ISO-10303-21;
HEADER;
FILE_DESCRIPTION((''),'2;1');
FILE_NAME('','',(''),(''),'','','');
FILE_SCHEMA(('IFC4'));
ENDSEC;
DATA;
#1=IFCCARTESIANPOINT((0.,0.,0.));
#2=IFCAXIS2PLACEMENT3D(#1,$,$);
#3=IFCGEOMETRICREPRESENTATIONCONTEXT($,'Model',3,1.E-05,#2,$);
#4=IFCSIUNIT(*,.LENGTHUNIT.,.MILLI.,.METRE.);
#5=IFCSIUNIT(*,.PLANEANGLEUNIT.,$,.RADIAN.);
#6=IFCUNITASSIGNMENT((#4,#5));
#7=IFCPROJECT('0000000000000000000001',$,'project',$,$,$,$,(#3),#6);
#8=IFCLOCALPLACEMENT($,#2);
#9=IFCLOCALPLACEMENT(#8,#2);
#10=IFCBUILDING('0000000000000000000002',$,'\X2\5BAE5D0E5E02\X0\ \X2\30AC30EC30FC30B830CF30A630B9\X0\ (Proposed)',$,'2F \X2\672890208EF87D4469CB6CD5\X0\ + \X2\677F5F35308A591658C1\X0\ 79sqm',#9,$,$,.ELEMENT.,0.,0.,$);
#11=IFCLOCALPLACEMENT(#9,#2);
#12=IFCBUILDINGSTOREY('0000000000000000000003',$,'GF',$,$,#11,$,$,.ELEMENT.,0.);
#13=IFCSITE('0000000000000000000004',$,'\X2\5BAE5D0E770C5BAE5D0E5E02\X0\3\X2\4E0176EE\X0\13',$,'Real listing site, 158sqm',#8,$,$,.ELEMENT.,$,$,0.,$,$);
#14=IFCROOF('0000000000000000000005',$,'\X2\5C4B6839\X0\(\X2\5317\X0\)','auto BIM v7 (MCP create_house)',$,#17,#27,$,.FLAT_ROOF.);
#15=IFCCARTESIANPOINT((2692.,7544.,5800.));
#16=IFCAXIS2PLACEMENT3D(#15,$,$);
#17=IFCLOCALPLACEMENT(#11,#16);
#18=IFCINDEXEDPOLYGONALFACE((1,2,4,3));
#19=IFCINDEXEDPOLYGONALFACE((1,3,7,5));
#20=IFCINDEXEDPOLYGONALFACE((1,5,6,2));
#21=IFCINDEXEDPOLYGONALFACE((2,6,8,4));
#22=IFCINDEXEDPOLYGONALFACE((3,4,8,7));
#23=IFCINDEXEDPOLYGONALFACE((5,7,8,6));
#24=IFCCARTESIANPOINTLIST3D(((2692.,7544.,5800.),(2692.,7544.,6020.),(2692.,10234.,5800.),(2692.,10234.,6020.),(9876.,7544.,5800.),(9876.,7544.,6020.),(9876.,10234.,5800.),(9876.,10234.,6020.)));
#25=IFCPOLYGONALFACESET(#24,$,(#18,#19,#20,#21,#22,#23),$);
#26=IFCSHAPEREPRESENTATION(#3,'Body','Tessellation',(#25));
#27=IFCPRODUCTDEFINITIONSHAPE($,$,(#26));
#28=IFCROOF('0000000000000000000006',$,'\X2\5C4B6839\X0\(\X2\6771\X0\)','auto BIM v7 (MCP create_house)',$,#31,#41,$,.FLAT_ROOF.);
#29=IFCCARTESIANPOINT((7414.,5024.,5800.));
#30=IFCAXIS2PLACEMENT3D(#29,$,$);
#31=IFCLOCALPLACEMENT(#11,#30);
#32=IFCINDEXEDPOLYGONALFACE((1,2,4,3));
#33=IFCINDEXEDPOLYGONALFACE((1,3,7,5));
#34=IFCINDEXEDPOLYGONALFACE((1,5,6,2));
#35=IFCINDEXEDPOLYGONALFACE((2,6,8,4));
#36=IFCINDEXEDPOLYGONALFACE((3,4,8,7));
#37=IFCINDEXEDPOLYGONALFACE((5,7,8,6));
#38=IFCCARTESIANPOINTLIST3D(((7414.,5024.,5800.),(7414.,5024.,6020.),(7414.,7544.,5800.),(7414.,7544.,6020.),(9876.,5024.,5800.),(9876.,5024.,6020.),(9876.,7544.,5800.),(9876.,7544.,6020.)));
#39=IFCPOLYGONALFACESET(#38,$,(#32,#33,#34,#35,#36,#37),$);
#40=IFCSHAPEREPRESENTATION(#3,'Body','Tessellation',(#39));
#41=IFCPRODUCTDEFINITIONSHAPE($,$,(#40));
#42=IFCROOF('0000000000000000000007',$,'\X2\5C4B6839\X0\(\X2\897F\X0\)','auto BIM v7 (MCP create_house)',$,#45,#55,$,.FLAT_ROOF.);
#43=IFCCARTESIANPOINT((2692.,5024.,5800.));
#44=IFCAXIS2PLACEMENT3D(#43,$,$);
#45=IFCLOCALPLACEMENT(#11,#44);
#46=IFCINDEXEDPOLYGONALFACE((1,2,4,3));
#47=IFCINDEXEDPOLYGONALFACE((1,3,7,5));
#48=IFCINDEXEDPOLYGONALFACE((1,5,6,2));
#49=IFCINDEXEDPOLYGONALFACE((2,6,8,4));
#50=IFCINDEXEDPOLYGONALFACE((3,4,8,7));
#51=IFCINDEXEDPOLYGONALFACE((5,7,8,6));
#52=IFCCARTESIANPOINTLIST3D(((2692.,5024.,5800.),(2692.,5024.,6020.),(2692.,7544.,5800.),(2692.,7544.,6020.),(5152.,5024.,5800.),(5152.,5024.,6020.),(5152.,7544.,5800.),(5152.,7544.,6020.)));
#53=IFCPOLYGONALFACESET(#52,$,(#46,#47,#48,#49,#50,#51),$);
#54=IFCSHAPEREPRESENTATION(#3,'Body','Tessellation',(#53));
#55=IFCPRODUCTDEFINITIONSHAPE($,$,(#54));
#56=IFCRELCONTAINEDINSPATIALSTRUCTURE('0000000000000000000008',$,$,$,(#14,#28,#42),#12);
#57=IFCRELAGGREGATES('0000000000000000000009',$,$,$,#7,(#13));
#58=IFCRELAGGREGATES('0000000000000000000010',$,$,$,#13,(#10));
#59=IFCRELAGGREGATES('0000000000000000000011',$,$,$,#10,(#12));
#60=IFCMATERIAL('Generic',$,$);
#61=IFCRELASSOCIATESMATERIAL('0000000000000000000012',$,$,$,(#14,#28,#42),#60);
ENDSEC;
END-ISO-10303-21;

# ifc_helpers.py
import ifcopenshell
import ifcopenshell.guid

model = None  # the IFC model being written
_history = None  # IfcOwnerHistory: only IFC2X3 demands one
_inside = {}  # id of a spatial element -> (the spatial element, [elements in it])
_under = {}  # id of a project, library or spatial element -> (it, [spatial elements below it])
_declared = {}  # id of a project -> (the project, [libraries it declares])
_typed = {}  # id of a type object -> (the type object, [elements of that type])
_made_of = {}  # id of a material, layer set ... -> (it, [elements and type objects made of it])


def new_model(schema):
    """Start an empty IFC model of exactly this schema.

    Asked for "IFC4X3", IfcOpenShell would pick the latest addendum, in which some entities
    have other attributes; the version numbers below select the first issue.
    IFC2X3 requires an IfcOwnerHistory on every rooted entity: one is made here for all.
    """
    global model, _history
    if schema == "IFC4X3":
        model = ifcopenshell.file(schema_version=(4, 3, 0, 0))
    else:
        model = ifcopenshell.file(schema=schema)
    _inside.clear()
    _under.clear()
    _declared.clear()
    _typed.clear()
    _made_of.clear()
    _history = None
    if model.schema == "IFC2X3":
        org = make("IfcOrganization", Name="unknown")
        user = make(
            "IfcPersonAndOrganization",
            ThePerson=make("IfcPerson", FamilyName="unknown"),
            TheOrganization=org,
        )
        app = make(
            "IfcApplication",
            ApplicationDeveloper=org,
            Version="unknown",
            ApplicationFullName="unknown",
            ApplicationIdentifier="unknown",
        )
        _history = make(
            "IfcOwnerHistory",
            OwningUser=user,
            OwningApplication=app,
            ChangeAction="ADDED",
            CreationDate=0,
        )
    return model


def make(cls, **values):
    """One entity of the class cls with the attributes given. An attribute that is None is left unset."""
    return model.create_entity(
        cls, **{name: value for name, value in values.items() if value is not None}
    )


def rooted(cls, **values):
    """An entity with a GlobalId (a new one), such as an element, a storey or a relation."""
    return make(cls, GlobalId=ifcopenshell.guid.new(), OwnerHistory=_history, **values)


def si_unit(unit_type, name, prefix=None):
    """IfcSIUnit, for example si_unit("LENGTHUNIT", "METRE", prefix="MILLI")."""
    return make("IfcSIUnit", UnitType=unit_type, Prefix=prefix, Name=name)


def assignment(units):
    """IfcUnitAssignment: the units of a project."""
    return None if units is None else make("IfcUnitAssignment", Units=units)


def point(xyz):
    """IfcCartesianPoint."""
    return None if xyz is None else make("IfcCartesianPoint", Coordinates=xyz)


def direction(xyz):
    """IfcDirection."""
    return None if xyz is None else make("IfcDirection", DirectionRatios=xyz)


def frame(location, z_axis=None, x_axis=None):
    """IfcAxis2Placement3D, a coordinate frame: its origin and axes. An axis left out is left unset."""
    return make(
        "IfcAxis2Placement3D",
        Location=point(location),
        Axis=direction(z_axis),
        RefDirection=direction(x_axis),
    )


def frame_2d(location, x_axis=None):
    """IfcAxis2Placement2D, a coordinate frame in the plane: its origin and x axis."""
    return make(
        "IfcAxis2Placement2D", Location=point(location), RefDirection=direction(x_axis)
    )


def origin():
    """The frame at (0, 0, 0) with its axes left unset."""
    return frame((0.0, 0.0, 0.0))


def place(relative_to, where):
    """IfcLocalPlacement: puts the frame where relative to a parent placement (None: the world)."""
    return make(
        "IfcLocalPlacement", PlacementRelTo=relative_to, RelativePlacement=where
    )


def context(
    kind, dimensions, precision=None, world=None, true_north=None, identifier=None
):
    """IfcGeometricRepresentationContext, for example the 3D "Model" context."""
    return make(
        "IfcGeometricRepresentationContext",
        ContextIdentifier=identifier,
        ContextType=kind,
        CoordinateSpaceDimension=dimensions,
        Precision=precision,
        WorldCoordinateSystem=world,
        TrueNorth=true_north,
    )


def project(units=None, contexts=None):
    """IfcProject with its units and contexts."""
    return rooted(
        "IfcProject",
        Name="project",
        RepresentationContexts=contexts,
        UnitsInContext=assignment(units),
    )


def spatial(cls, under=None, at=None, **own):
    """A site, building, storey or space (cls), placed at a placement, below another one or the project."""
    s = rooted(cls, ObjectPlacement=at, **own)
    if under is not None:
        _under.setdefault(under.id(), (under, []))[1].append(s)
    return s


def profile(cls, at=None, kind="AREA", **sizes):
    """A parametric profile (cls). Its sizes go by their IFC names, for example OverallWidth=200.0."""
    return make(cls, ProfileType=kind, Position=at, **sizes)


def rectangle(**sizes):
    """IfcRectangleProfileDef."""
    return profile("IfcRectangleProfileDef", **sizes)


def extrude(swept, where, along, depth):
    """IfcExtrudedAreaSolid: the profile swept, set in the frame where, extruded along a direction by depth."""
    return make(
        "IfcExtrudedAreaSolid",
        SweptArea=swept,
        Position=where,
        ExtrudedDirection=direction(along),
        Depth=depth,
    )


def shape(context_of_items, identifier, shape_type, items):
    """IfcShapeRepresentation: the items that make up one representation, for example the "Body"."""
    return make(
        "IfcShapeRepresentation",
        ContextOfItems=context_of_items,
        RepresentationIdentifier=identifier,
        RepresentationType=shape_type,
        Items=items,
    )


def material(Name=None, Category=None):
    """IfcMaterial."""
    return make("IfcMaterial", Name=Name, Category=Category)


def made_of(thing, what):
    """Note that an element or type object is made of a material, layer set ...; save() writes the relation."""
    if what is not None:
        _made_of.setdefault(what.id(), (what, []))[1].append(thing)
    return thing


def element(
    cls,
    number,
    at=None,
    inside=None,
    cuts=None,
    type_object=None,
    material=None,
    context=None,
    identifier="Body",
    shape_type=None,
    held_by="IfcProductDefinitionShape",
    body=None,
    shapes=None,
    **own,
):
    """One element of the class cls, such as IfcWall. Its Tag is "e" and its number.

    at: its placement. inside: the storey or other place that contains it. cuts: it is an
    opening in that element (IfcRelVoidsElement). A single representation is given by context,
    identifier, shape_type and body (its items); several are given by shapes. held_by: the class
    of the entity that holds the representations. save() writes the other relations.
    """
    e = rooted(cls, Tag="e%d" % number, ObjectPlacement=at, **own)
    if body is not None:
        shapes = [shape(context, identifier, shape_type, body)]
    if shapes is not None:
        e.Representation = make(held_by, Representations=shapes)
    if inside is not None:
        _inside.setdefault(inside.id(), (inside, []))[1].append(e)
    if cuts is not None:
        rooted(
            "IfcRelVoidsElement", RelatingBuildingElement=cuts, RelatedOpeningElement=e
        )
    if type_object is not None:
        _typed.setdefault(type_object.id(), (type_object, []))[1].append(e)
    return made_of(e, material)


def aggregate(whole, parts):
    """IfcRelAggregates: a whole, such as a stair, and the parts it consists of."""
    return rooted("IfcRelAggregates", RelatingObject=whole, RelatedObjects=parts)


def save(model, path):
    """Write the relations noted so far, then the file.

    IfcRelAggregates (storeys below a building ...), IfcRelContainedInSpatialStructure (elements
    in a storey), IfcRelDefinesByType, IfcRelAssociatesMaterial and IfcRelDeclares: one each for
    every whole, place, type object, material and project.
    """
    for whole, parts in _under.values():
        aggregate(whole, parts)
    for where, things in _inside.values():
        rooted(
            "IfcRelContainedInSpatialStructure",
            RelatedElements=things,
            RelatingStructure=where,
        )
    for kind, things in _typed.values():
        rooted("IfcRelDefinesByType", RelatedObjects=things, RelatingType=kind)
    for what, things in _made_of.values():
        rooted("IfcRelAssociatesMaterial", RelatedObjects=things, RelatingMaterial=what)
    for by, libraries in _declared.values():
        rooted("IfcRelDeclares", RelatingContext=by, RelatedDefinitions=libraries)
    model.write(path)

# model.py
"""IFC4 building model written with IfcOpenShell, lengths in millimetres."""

from ifc_helpers import new_model, si_unit, frame, frame_2d, origin, place, context, project, spatial, rectangle, extrude, material, element, save


model = new_model("IFC4")

# Units and contexts
model_context = context("Model", 3, precision=1e-05, world=origin())
ifc_project = project(units=[si_unit("LENGTHUNIT", "METRE", prefix="MILLI"), si_unit("PLANEANGLEUNIT", "RADIAN")], contexts=[model_context])

# Site, building, storey
site_placement = place(None, origin())
site = spatial("IfcSite", under=ifc_project, at=site_placement, Name="宮崎県宮崎市3丁目13", ObjectType="Real listing site, 158sqm", CompositionType="ELEMENT", RefElevation=0.0)
building_placement = place(site_placement, origin())
building = spatial("IfcBuilding", under=site, at=building_placement, Name="宮崎市 ガレージハウス (Proposed)", ObjectType="2F 木造軸組構法 + 板張り外壁 79sqm", CompositionType="ELEMENT", ElevationOfRefHeight=0.0, ElevationOfTerrain=0.0)
storey_placement = place(building_placement, origin())
storey = spatial("IfcBuildingStorey", under=building, at=storey_placement, Name="GF", CompositionType="ELEMENT", Elevation=0.0)

# Shared definitions
ifc_material = material(Name="Generic")

# Roofs
roof_1_placement = place(storey_placement, frame((2692.0, 7544.0, 5800.0)))
element("IfcRoof", 1, at=roof_1_placement, inside=storey, material=ifc_material, Name="屋根(北)", Description="auto BIM v7 (MCP create_house)", PredefinedType="FLAT_ROOF", context=model_context, shape_type="SweptSolid", body=[
    extrude(rectangle(XDim=7184.0, YDim=2690.0, at=frame_2d((3592.0, 1345.0))), frame((2692.0, 7544.0, 5800.0)), (0.0, 0.0, 1.0), 220.0),
])
roof_2_placement = place(storey_placement, frame((7414.0, 5024.0, 5800.0)))
element("IfcRoof", 2, at=roof_2_placement, inside=storey, material=ifc_material, Name="屋根(東)", Description="auto BIM v7 (MCP create_house)", PredefinedType="FLAT_ROOF", context=model_context, shape_type="SweptSolid", body=[
    extrude(rectangle(XDim=2462.0, YDim=2520.0, at=frame_2d((1231.0, 1260.0))), frame((7414.0, 5024.0, 5800.0)), (0.0, 0.0, 1.0), 220.0),
])
roof_3_placement = place(storey_placement, frame((2692.0, 5024.0, 5800.0)))
element("IfcRoof", 3, at=roof_3_placement, inside=storey, material=ifc_material, Name="屋根(西)", Description="auto BIM v7 (MCP create_house)", PredefinedType="FLAT_ROOF", context=model_context, shape_type="SweptSolid", body=[
    extrude(rectangle(XDim=2460.0, YDim=2520.0, at=frame_2d((1230.0, 1260.0))), frame((2692.0, 5024.0, 5800.0)), (0.0, 0.0, 1.0), 220.0),
])

save(model, "model.ifc")
